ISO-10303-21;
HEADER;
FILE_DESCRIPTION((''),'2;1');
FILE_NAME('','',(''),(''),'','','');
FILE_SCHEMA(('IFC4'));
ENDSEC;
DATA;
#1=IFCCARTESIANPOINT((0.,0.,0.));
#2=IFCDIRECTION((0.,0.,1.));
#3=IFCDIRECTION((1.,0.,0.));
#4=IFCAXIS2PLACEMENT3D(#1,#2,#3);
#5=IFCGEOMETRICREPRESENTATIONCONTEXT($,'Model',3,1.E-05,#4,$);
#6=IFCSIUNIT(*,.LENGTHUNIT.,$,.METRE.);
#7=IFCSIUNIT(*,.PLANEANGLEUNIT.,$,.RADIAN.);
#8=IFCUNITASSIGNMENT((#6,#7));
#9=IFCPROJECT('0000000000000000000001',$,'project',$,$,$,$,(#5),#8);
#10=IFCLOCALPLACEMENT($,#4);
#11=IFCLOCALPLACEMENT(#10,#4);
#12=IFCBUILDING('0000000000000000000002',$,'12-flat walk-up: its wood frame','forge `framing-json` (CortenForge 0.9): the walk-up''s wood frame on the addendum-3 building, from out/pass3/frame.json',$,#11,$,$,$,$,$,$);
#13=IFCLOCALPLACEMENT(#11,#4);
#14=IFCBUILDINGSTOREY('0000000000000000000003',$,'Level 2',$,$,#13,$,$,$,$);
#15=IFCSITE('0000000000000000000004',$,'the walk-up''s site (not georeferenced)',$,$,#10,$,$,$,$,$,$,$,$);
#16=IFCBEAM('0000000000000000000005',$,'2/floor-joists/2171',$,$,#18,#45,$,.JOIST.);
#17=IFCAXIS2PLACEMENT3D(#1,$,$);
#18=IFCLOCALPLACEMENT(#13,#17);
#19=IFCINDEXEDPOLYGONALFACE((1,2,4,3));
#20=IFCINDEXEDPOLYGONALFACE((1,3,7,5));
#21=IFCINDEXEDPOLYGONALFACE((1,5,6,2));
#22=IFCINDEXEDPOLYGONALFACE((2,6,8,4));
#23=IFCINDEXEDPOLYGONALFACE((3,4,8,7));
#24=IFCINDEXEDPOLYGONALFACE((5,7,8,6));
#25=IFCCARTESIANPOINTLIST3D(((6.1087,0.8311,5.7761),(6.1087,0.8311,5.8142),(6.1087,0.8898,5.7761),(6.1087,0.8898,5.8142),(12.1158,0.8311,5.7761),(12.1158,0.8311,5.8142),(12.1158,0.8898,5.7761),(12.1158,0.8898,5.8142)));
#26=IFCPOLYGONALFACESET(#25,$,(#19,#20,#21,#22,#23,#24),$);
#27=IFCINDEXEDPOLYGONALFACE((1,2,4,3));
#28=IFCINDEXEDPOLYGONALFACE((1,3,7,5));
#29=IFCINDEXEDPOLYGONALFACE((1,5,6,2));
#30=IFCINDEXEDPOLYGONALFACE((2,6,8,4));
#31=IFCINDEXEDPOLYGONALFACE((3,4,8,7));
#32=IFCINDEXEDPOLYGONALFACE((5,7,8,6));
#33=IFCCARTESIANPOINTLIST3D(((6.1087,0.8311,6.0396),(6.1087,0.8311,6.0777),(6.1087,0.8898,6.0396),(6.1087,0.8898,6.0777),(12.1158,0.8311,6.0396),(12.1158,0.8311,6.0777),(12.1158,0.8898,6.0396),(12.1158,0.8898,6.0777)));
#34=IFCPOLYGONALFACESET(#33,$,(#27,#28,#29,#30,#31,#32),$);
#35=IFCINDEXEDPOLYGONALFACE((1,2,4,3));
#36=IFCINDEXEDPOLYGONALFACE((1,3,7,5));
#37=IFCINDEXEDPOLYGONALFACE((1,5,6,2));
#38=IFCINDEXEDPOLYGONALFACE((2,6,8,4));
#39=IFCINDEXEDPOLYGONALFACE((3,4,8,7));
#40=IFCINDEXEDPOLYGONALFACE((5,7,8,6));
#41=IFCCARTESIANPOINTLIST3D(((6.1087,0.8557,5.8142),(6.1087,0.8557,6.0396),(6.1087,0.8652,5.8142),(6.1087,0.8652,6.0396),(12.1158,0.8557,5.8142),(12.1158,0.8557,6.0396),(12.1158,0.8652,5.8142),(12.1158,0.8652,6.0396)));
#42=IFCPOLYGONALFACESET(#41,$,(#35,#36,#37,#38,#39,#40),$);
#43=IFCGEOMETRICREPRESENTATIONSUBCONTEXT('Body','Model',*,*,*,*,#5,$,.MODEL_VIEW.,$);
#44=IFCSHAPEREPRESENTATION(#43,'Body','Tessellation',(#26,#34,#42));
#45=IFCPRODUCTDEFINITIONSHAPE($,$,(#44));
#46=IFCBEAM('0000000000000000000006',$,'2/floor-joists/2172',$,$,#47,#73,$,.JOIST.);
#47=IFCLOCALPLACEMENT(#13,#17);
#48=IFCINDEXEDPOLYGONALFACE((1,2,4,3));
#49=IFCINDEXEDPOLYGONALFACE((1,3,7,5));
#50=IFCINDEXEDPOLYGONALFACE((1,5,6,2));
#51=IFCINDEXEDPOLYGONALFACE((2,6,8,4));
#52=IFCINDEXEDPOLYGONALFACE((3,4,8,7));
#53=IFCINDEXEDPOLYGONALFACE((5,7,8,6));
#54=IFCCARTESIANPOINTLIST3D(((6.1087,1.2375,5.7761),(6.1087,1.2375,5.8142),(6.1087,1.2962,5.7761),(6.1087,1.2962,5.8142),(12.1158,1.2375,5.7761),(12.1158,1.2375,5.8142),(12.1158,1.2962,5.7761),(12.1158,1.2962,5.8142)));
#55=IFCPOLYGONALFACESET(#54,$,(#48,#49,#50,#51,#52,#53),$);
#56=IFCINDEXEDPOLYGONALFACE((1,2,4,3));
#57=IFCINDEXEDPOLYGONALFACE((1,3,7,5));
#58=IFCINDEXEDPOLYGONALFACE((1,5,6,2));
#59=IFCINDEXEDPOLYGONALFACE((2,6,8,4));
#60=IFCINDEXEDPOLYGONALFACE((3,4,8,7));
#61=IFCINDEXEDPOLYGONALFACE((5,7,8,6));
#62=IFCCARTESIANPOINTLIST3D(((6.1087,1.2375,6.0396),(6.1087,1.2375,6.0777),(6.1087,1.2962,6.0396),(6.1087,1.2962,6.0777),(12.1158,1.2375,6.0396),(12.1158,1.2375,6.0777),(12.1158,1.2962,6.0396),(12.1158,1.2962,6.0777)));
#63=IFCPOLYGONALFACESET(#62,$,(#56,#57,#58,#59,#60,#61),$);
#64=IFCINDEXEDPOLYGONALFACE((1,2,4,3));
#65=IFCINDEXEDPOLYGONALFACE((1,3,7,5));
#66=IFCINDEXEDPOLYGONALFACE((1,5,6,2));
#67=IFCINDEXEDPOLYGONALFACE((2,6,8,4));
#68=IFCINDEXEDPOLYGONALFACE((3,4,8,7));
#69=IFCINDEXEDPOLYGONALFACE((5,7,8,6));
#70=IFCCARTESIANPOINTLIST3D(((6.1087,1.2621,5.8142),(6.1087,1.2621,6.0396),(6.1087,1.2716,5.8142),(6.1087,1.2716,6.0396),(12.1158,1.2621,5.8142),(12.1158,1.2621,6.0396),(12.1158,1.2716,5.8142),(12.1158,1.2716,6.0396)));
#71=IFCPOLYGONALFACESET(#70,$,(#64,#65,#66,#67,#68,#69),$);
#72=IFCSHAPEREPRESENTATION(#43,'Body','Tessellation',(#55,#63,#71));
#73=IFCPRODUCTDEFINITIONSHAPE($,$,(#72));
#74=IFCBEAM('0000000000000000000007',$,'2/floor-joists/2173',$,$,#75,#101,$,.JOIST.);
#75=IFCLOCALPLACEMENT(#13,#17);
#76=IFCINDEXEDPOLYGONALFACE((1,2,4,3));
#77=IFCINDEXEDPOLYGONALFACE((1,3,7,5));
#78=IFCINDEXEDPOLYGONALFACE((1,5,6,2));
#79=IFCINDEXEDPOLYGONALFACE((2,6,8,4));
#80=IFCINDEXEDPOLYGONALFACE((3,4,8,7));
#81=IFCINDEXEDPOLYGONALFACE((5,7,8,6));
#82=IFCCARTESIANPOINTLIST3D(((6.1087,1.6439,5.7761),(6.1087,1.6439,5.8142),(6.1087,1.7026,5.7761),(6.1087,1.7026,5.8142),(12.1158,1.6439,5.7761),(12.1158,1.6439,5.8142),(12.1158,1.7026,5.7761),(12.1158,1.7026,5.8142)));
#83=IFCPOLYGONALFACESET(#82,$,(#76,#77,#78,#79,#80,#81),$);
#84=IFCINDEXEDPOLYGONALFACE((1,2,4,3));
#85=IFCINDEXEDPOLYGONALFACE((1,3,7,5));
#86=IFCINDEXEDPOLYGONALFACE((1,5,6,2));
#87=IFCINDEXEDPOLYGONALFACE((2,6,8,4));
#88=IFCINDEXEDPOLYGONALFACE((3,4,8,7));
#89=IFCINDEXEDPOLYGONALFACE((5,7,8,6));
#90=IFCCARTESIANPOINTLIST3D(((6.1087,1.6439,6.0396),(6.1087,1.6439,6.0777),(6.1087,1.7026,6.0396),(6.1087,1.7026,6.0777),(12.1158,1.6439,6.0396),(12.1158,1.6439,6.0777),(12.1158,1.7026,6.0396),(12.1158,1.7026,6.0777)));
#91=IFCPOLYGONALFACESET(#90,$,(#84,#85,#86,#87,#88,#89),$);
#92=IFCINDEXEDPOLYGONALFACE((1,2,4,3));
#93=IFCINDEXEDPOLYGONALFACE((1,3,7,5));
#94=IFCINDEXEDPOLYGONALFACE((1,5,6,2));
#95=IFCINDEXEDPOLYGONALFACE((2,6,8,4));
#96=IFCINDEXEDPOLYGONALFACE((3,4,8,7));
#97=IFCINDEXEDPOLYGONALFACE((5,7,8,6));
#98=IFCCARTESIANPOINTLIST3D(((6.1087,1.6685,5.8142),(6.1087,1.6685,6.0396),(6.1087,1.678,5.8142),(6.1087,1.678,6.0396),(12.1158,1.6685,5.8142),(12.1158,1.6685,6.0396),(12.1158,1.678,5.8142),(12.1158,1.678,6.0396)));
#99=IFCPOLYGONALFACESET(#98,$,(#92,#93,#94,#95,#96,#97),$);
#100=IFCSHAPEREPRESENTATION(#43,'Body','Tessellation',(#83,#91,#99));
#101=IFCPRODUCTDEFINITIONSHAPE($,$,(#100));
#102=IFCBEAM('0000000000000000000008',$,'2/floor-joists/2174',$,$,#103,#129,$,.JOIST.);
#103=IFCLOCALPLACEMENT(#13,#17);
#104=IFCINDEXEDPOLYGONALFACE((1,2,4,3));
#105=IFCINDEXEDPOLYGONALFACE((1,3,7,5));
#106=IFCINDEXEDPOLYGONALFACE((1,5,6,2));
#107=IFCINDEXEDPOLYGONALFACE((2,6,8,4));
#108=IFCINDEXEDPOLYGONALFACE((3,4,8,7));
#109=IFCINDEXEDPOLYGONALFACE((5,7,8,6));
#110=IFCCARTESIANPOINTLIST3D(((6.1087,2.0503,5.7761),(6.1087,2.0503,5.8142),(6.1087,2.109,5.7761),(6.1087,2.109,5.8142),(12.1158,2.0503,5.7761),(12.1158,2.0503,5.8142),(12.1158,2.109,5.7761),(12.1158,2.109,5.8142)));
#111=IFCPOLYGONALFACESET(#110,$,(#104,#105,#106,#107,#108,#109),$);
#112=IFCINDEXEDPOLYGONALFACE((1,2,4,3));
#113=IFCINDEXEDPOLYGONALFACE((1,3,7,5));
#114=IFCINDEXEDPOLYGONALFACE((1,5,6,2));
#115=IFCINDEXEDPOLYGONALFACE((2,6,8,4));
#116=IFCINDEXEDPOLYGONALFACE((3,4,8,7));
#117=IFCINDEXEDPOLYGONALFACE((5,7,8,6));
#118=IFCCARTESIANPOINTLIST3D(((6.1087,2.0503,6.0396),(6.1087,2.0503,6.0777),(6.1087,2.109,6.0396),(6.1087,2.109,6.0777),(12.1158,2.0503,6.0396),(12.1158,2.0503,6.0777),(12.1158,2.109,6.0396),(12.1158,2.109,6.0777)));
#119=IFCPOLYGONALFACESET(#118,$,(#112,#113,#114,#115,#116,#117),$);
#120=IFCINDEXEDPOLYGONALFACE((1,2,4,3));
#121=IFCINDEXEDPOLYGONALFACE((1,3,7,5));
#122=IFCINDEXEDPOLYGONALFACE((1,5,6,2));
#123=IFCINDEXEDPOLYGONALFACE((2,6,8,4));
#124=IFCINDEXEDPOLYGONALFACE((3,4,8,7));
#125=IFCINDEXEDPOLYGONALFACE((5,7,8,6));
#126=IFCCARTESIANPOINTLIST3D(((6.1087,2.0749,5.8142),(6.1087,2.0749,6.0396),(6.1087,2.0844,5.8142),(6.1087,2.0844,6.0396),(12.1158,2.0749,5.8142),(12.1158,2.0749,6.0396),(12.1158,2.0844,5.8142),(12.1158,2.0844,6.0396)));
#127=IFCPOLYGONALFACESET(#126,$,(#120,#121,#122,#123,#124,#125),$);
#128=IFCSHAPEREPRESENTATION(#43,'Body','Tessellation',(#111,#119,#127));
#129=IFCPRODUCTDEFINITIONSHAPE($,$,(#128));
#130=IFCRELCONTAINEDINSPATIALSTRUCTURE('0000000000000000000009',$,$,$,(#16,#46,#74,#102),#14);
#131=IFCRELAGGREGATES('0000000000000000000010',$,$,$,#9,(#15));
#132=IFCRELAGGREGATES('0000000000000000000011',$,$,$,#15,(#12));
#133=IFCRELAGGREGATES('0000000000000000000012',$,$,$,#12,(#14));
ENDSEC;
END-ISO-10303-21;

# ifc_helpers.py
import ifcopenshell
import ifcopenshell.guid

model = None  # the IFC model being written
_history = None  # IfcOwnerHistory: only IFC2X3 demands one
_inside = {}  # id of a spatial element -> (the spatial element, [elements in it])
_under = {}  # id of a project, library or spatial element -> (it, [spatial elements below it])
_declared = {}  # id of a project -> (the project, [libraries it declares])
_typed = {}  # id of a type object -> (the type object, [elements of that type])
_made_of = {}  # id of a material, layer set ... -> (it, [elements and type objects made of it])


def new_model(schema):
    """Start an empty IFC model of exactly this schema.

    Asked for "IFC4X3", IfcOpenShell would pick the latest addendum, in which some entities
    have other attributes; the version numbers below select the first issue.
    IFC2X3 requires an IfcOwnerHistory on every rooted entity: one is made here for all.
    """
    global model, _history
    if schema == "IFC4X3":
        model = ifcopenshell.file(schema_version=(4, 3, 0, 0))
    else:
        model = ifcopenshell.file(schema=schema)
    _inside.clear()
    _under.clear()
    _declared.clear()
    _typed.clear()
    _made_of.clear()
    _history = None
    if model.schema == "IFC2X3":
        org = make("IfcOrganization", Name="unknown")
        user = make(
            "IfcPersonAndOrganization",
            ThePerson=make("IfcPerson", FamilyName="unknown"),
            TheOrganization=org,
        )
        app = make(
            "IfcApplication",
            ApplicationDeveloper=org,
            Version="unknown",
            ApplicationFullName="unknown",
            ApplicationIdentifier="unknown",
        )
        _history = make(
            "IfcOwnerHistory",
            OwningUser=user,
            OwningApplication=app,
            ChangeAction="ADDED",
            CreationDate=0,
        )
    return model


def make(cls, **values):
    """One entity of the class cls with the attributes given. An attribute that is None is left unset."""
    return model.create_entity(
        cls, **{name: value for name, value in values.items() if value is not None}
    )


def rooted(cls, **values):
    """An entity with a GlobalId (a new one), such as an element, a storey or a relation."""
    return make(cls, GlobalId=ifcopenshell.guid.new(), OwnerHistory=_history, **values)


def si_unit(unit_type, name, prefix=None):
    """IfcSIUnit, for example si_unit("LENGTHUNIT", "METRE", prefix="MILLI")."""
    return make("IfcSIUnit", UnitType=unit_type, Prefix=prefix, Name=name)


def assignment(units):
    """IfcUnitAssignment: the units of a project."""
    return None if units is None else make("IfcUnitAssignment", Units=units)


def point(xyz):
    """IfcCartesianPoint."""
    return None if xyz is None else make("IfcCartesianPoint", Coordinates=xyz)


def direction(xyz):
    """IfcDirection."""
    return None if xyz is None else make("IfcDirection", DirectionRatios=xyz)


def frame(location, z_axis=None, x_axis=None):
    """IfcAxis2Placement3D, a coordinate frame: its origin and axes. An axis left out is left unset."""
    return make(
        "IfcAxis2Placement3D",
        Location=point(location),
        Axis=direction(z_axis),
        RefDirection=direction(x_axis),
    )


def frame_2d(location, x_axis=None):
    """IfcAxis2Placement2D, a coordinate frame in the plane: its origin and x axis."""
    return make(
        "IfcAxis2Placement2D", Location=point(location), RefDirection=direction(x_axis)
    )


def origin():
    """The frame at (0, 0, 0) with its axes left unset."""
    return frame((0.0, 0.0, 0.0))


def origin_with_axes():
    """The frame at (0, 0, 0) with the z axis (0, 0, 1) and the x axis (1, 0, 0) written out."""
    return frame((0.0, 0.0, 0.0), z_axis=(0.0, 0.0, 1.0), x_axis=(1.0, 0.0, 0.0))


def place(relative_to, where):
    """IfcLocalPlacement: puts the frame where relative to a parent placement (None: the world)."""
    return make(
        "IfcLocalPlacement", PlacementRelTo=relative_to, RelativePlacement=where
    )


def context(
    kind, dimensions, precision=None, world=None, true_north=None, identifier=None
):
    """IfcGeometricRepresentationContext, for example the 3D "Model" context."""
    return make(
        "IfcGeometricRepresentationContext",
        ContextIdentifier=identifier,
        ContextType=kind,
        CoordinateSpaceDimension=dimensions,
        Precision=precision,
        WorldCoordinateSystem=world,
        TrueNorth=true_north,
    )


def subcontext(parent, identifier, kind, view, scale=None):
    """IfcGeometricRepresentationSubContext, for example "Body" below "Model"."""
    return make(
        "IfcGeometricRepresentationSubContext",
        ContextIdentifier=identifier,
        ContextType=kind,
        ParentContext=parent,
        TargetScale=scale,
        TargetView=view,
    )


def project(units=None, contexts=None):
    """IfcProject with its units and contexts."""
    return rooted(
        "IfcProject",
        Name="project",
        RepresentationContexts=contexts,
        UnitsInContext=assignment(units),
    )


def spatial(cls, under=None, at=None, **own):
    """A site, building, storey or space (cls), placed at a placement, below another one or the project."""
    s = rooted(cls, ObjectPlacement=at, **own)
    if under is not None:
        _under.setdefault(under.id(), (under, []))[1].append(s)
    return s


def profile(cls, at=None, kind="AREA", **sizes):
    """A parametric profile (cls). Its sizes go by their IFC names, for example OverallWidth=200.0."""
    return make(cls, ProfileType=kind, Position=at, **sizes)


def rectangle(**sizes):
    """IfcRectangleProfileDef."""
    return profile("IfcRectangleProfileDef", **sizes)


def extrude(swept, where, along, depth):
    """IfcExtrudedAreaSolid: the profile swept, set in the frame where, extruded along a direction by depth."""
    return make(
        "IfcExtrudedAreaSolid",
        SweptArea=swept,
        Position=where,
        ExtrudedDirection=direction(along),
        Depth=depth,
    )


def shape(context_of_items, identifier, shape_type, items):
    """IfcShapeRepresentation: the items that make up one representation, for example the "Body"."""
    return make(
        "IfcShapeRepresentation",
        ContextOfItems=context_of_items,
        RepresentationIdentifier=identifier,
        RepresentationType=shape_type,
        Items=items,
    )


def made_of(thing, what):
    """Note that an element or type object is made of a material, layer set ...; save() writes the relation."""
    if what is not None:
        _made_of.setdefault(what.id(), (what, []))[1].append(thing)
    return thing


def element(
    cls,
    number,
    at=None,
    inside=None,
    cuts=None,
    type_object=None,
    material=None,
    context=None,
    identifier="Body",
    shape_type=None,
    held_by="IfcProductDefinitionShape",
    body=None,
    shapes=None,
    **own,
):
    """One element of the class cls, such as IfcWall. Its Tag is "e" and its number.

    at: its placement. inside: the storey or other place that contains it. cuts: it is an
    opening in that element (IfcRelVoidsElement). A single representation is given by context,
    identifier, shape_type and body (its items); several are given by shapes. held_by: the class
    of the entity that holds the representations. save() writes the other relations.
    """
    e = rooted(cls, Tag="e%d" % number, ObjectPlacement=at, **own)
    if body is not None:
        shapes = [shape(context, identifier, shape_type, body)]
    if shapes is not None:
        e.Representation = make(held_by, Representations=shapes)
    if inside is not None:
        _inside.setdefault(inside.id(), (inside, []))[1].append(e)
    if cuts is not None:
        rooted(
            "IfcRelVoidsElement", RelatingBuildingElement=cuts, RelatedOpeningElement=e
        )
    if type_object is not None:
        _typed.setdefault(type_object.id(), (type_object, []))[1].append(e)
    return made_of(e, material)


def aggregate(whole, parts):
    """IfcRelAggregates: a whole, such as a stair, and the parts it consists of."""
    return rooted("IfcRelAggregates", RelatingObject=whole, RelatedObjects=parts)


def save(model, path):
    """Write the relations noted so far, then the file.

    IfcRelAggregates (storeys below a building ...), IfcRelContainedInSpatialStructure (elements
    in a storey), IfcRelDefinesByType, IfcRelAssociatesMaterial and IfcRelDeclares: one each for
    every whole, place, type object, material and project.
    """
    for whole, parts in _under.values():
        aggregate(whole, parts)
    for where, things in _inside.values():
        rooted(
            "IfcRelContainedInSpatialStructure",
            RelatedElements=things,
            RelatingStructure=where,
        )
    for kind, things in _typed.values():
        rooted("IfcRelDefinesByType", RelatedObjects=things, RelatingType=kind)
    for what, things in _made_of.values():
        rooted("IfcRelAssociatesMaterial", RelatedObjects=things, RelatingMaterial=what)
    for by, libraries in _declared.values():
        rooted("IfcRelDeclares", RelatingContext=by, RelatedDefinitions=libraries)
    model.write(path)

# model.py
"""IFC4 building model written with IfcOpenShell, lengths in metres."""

from ifc_helpers import new_model, si_unit, frame, frame_2d, origin, origin_with_axes, place, context, subcontext, project, spatial, rectangle, extrude, element, save


model = new_model("IFC4")

# Units and contexts
model_context = context("Model", 3, precision=1e-05, world=origin_with_axes())
body_context = subcontext(model_context, "Body", "Model", "MODEL_VIEW")
ifc_project = project(units=[si_unit("LENGTHUNIT", "METRE"), si_unit("PLANEANGLEUNIT", "RADIAN")], contexts=[model_context])

# Site, building, storey
site_placement = place(None, origin_with_axes())
site = spatial("IfcSite", under=ifc_project, at=site_placement, Name="the walk-up's site (not georeferenced)")
building_placement = place(site_placement, origin_with_axes())
building = spatial("IfcBuilding", under=site, at=building_placement, Name="12-flat walk-up: its wood frame", Description="forge `framing-json` (CortenForge 0.9): the walk-up's wood frame on the addendum-3 building, from out/pass3/frame.json")
storey_placement = place(building_placement, origin_with_axes())
storey = spatial("IfcBuildingStorey", under=building, at=storey_placement, Name="Level 2")

# Beams
beam_1_placement = place(storey_placement, frame((6.1087, 0.8311, 5.7761), z_axis=(0.0, 0.0, 1.0), x_axis=(1.0, 0.0, 0.0)))
element("IfcBeam", 1, at=beam_1_placement, inside=storey, Name="2/floor-joists/2171", PredefinedType="JOIST", context=body_context, shape_type="SweptSolid", body=[
    extrude(rectangle(XDim=6.0071, YDim=0.0587, at=frame_2d((3.0036, 0.0294))), origin(), (0.0, 0.0, 1.0), 0.0381),
    extrude(rectangle(XDim=6.0071, YDim=0.0587, at=frame_2d((3.0036, 0.0294))), frame((0.0, 0.0, 0.2635)), (0.0, 0.0, 1.0), 0.0381),
    extrude(rectangle(XDim=6.0071, YDim=0.0095, at=frame_2d((3.0036, 0.0048))), frame((0.0, 0.0246, 0.0381)), (0.0, 0.0, 1.0), 0.2254),
])
beam_2_placement = place(storey_placement, frame((6.1087, 1.2375, 5.7761), z_axis=(0.0, 0.0, 1.0), x_axis=(1.0, 0.0, 0.0)))
element("IfcBeam", 2, at=beam_2_placement, inside=storey, Name="2/floor-joists/2172", PredefinedType="JOIST", context=body_context, shape_type="SweptSolid", body=[
    extrude(rectangle(XDim=6.0071, YDim=0.0587, at=frame_2d((3.0036, 0.0294))), origin(), (0.0, 0.0, 1.0), 0.0381),
    extrude(rectangle(XDim=6.0071, YDim=0.0587, at=frame_2d((3.0036, 0.0294))), frame((0.0, 0.0, 0.2635)), (0.0, 0.0, 1.0), 0.0381),
    extrude(rectangle(XDim=6.0071, YDim=0.0095, at=frame_2d((3.0036, 0.0048))), frame((0.0, 0.0246, 0.0381)), (0.0, 0.0, 1.0), 0.2254),
])
beam_3_placement = place(storey_placement, frame((6.1087, 1.6439, 5.7761), z_axis=(0.0, 0.0, 1.0), x_axis=(1.0, 0.0, 0.0)))
element("IfcBeam", 3, at=beam_3_placement, inside=storey, Name="2/floor-joists/2173", PredefinedType="JOIST", context=body_context, shape_type="SweptSolid", body=[
    extrude(rectangle(XDim=6.0071, YDim=0.0587, at=frame_2d((3.0036, 0.0294))), origin(), (0.0, 0.0, 1.0), 0.0381),
    extrude(rectangle(XDim=6.0071, YDim=0.0587, at=frame_2d((3.0036, 0.0294))), frame((0.0, 0.0, 0.2635)), (0.0, 0.0, 1.0), 0.0381),
    extrude(rectangle(XDim=6.0071, YDim=0.0095, at=frame_2d((3.0036, 0.0048))), frame((0.0, 0.0246, 0.0381)), (0.0, 0.0, 1.0), 0.2254),
])
beam_4_placement = place(storey_placement, frame((6.1087, 2.0503, 5.7761), z_axis=(0.0, 0.0, 1.0), x_axis=(1.0, 0.0, 0.0)))
element("IfcBeam", 4, at=beam_4_placement, inside=storey, Name="2/floor-joists/2174", PredefinedType="JOIST", context=body_context, shape_type="SweptSolid", body=[
    extrude(rectangle(XDim=6.0071, YDim=0.0587, at=frame_2d((3.0036, 0.0294))), origin(), (0.0, 0.0, 1.0), 0.0381),
    extrude(rectangle(XDim=6.0071, YDim=0.0587, at=frame_2d((3.0036, 0.0294))), frame((0.0, 0.0, 0.2635)), (0.0, 0.0, 1.0), 0.0381),
    extrude(rectangle(XDim=6.0071, YDim=0.0095, at=frame_2d((3.0036, 0.0048))), frame((0.0, 0.0246, 0.0381)), (0.0, 0.0, 1.0), 0.2254),
])

save(model, "model.ifc")
